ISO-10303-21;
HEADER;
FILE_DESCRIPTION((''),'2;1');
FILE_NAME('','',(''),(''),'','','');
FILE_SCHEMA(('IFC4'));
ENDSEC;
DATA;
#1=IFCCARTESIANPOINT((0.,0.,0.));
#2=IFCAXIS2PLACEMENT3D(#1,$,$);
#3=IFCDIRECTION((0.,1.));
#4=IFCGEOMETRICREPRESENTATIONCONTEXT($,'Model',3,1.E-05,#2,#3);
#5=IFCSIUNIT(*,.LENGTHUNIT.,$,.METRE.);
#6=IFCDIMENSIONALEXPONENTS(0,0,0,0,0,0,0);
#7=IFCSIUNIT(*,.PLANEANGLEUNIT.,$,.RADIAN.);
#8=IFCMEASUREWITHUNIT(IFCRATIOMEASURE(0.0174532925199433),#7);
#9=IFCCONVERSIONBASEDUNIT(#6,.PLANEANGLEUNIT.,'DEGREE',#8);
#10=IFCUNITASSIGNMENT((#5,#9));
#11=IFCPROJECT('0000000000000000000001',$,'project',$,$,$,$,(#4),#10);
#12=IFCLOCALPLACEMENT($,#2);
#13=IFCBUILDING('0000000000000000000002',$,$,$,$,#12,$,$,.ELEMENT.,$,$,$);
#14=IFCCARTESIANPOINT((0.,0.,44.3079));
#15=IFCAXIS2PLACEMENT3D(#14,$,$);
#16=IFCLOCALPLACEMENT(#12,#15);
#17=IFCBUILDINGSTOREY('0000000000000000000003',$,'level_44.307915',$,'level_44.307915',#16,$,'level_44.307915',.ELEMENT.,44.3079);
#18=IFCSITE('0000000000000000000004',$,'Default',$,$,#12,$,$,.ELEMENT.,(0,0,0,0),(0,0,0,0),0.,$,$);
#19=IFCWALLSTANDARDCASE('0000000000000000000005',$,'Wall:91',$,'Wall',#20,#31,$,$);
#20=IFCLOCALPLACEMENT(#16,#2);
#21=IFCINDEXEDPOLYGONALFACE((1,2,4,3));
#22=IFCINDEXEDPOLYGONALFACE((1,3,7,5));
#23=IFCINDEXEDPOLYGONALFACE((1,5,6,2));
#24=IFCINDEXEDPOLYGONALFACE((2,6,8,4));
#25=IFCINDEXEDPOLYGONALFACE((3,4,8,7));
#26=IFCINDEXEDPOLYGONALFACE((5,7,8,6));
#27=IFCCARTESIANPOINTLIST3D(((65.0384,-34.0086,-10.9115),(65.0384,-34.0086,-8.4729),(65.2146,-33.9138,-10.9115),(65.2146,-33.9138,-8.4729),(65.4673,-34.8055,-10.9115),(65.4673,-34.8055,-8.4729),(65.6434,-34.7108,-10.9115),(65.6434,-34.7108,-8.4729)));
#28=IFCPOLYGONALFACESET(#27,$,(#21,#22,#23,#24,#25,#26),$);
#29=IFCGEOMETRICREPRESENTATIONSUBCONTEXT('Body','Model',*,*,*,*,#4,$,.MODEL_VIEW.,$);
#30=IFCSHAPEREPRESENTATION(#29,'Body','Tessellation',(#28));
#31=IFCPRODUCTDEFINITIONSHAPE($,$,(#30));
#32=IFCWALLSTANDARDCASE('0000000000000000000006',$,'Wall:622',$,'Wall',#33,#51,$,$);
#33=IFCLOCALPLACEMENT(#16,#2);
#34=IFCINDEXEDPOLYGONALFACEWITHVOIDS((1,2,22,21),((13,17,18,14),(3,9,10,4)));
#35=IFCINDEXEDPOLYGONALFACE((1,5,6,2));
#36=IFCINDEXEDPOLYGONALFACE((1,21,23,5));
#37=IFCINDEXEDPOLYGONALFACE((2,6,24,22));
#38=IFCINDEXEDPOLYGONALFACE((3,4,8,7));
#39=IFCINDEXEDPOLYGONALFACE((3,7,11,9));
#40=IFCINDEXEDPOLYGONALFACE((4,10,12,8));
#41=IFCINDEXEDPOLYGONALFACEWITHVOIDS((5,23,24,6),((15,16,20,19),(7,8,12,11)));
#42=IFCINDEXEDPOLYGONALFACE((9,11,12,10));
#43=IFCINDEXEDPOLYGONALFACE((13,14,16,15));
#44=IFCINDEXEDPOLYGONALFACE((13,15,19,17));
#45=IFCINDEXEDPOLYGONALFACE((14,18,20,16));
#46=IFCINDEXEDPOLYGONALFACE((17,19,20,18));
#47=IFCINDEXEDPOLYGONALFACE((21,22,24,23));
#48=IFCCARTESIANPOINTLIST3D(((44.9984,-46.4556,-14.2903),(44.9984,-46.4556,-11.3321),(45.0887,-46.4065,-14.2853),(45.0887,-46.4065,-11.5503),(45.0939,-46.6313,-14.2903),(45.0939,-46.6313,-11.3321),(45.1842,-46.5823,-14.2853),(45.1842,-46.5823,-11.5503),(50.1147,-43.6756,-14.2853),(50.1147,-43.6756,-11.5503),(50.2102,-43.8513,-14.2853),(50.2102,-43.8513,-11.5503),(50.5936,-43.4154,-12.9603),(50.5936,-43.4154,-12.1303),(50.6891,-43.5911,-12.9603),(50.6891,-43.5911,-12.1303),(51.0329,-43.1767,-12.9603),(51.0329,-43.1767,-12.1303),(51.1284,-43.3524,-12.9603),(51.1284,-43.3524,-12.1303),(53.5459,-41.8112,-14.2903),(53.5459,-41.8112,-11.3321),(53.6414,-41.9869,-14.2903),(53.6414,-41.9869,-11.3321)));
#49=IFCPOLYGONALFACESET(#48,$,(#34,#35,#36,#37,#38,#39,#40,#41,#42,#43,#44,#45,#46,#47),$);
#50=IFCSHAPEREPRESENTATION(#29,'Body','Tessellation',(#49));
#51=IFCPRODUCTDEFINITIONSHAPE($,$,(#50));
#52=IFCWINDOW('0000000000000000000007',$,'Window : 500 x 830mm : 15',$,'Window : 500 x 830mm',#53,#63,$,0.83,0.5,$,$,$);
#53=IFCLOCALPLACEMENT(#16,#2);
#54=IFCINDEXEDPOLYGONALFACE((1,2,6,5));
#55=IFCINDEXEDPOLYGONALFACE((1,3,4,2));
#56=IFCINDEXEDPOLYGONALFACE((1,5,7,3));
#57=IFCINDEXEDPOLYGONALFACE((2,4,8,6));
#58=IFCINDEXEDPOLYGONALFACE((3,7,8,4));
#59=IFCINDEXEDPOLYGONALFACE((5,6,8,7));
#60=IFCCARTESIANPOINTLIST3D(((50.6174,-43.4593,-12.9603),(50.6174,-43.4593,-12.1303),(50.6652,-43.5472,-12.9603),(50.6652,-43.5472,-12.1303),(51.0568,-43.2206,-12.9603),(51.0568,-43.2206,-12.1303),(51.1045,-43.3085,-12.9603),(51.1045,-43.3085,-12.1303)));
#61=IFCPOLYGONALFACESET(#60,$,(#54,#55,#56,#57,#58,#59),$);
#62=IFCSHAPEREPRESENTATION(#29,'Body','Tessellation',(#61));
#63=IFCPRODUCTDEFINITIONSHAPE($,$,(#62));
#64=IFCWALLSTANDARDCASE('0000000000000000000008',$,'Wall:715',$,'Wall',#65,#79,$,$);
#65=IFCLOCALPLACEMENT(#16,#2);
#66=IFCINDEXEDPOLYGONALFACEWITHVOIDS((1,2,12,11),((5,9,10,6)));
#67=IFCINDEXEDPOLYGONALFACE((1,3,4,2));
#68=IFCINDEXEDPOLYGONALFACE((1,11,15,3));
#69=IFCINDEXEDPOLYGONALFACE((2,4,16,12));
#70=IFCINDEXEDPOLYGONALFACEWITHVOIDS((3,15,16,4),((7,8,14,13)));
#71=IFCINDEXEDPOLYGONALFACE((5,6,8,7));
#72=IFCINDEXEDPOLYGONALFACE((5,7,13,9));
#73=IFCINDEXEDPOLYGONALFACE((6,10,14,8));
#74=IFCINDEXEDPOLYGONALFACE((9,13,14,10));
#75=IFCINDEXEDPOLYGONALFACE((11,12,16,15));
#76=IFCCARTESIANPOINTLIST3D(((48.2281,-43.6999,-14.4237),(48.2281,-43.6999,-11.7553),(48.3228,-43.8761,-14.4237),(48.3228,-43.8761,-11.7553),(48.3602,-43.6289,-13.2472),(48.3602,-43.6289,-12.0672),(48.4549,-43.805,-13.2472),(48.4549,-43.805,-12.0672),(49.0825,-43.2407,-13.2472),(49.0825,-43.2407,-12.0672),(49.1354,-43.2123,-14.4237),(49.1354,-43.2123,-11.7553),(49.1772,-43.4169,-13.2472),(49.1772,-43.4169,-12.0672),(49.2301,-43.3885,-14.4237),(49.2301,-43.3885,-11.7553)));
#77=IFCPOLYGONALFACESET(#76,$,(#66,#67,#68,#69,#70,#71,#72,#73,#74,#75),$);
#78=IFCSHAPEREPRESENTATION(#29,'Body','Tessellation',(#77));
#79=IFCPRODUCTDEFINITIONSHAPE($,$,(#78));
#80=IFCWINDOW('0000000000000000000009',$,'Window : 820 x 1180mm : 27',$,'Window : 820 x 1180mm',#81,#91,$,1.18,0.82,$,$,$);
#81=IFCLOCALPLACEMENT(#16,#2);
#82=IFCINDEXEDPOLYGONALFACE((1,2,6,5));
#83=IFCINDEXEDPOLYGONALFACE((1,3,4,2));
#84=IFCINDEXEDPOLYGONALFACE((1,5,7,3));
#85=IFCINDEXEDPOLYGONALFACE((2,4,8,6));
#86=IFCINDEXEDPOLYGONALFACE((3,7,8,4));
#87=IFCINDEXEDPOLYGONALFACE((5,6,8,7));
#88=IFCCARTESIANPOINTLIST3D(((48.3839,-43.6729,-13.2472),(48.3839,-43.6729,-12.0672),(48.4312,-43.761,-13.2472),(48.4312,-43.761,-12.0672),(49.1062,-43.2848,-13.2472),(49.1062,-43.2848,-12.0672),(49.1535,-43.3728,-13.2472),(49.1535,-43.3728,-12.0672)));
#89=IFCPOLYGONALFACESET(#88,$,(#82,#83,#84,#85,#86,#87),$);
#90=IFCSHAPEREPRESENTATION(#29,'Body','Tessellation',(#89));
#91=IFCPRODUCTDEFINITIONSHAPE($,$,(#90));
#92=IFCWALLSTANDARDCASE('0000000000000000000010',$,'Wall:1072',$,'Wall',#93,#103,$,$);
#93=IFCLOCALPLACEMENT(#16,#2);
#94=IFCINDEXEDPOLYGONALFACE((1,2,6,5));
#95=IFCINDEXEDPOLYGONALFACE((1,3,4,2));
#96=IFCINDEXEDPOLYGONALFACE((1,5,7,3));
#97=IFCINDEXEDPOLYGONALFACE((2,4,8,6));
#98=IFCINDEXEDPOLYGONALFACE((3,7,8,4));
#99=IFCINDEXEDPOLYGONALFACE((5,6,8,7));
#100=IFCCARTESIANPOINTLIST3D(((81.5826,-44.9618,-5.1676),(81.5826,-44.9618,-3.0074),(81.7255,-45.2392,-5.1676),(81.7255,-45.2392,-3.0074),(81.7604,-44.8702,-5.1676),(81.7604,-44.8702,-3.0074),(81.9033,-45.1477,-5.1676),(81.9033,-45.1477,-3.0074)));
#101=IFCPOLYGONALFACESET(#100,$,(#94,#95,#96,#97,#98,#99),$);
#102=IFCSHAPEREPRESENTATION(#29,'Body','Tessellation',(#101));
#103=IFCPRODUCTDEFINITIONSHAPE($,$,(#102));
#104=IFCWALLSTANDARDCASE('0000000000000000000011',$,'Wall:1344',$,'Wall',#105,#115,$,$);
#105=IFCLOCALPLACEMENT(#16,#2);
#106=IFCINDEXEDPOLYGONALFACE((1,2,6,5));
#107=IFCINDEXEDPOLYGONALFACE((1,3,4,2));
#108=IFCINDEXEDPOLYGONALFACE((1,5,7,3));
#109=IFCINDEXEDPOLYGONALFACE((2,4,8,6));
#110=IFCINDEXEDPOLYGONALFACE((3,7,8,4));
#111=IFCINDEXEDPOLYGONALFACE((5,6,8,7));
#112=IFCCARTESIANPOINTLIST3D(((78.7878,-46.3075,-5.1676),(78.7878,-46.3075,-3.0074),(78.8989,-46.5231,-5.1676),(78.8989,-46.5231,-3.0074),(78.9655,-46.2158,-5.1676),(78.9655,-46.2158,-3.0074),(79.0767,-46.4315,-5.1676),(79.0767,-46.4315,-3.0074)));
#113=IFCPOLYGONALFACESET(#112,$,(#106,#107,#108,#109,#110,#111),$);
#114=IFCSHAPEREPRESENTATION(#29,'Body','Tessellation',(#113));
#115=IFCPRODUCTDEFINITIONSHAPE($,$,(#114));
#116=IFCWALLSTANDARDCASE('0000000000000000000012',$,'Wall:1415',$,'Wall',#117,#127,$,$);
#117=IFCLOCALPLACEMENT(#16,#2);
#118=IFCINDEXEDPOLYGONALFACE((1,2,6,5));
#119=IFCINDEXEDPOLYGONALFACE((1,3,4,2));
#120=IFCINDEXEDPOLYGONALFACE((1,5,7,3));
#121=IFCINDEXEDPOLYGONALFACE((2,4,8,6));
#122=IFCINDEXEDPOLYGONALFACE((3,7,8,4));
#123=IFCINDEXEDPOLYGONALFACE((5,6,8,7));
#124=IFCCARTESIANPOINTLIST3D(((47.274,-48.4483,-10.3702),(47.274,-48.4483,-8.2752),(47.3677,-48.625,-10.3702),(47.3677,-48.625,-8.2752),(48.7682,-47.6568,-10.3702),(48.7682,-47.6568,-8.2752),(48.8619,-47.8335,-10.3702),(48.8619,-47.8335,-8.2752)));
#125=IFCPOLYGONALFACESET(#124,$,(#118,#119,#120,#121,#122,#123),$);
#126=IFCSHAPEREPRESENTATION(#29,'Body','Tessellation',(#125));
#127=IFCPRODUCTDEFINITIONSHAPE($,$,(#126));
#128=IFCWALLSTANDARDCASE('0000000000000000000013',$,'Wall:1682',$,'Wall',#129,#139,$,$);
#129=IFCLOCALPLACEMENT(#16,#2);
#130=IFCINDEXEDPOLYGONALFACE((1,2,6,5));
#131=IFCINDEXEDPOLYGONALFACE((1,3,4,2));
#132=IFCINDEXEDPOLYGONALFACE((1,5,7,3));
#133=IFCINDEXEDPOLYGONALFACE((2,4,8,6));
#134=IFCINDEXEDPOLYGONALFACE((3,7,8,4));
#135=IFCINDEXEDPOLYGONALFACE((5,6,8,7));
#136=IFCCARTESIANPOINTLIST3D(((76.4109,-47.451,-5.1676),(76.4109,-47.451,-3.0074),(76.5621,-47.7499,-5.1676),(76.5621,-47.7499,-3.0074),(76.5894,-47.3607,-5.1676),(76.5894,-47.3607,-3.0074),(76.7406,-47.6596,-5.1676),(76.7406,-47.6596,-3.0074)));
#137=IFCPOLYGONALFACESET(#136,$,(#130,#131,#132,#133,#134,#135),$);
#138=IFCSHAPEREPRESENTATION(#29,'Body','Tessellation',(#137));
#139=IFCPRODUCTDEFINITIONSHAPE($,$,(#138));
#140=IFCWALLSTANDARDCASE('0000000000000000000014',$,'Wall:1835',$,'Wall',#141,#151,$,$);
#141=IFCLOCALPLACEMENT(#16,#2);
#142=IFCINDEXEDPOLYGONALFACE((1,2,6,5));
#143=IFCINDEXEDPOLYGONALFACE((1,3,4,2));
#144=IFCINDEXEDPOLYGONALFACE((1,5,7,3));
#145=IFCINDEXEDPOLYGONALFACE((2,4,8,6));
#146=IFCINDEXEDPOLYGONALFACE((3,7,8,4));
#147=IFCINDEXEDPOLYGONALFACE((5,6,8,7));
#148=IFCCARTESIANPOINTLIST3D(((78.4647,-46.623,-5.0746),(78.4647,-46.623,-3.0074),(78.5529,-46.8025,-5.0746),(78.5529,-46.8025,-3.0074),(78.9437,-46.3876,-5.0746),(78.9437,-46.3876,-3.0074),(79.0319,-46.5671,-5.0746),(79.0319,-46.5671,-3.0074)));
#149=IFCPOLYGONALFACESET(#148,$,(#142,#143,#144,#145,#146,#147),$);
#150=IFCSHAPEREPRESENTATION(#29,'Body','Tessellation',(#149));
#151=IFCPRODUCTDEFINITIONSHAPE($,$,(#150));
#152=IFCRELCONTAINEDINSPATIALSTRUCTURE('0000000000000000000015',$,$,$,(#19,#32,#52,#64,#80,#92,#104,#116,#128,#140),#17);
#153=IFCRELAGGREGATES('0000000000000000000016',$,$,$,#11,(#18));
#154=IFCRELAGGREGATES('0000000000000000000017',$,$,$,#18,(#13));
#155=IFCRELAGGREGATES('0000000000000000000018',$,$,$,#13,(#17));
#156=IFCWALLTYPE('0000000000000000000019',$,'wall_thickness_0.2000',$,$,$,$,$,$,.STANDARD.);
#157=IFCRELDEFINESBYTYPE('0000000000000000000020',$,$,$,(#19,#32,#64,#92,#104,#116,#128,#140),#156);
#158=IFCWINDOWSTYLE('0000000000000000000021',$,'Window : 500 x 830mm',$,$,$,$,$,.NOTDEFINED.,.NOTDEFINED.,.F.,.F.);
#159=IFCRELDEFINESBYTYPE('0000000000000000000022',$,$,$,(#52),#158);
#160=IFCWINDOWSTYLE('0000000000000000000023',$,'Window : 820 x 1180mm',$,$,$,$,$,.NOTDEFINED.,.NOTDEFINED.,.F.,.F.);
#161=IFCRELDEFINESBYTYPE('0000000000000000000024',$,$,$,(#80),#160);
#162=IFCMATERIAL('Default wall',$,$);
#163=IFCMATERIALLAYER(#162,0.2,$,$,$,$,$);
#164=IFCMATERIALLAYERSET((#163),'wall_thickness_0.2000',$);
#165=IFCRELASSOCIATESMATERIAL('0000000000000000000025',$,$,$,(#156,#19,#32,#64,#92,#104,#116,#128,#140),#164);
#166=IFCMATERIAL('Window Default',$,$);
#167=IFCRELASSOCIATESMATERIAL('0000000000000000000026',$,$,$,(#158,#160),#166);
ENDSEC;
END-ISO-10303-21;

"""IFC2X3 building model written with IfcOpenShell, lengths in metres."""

from ifc_helpers import new_model, entity, si_unit, converted_unit, direction, frame, frame_2d, origin, origin_2d_with_axis, place, context, subcontext, project, spatial, polyline, rectangle, outline, extrude, source, transform, mapped, material, layer, layer_set, layer_usage, type_object, type_shapes, element, fill, save


model = new_model("IFC2X3")

# Units and contexts
model_context = context("Model", 3, precision=1e-05, world=origin(), true_north=direction((0.0, 1.0)))
body_context = subcontext(model_context, "Body", "Model", "MODEL_VIEW")
ifc_project = project(units=[si_unit("LENGTHUNIT", "METRE"), converted_unit("PLANEANGLEUNIT", "DEGREE", entity("IfcRatioMeasure", 0.0174532925199433), si_unit("PLANEANGLEUNIT", "RADIAN"), dimensions=[0, 0, 0, 0, 0, 0, 0])], contexts=[model_context])

# Site, building, storey
placement_1 = place(None, origin())
site = spatial("IfcSite", under=ifc_project, at=placement_1, Name="Default", CompositionType="ELEMENT", RefLatitude=(0, 0, 0, 0), RefLongitude=(0, 0, 0, 0), RefElevation=0.0)
building = spatial("IfcBuilding", under=site, at=placement_1, CompositionType="ELEMENT")
storey_placement = place(placement_1, frame((0.0, 0.0, 44.3079)))
storey = spatial("IfcBuildingStorey", under=building, at=storey_placement, Name="level_44.307915", ObjectType="level_44.307915", LongName="level_44.307915", CompositionType="ELEMENT", Elevation=44.3079)

# Wall
ifc_material_1 = material(Name="Default wall")
ifc_layer = layer(ifc_material_1, 0.2)
ifc_layer_set = layer_set([ifc_layer], Name="wall_thickness_0.2000")
ifc_layer_usage = layer_usage(ifc_layer_set, "AXIS2", "POSITIVE", -0.1)
wall_type = type_object("IfcWallType", Name="wall_thickness_0.2000", PredefinedType="STANDARD", material=ifc_layer_set)
placement_2 = place(placement_1, frame((0.0, 0.0, 33.3964)))
wall_1_placement = place(placement_2, frame((65.5553, -34.7582, 0.0), z_axis=(0.0, 0.0, 1.0), x_axis=(-0.473866, 0.880597, 0.0)))
element("IfcWallStandardCase", 1, at=wall_1_placement, inside=storey, type_object=wall_type, material=ifc_layer_usage, Name="Wall:91", ObjectType="Wall", context=body_context, shape_type="SweptSolid", body=[
    extrude(outline(polyline([(0.905, -0.1), (0.905, 0.1), (0.0, 0.1), (0.0, -0.1), (0.905, -0.1)])), origin(), (0.0, 0.0, 1.0), 2.4386),
])

# Wall, openings, window
placement_3 = place(placement_1, frame((0.0, 0.0, 30.0176)))
wall_2_placement = place(placement_3, frame((45.0461, -46.5435, 0.0), z_axis=(0.0, 0.0, 1.0), x_axis=(0.878667, 0.477436, 0.0)))
wall_2 = element("IfcWallStandardCase", 2, at=wall_2_placement, inside=storey, type_object=wall_type, material=ifc_layer_usage, Name="Wall:622", ObjectType="Wall", context=body_context, shape_type="SweptSolid", body=[
    extrude(outline(polyline([(9.7278, -0.1), (9.7278, 0.1), (0.0, 0.1), (0.0, -0.1), (9.7278, -0.1)])), origin(), (0.0, 0.0, 1.0), 2.9582),
])
opening_1_placement = place(wall_2_placement, frame((0.1028, -0.1, 0.005)))
element("IfcOpeningElement", 3, at=opening_1_placement, cuts=wall_2, ObjectType="Opening", context=body_context, shape_type="SweptSolid", body=[
    extrude(rectangle(XDim=5.72, YDim=2.735, at=frame_2d((1.3675, 2.86), x_axis=(0.0, 1.0))), frame((0.0, 0.0, 0.0), z_axis=(0.0, 1.0, 0.0), x_axis=(0.0, 0.0, 1.0)), (0.0, 0.0, 1.0), 0.2),
])
opening_2_placement = place(wall_2_placement, frame((6.3678, -0.1, 1.33)))
opening_2 = element("IfcOpeningElement", 4, at=opening_2_placement, cuts=wall_2, ObjectType="Opening", context=body_context, shape_type="SweptSolid", body=[
    extrude(rectangle(XDim=0.5, YDim=0.83, at=frame_2d((0.415, 0.25), x_axis=(0.0, 1.0))), frame((0.0, 0.0, 0.0), z_axis=(0.0, 1.0, 0.0), x_axis=(0.0, 0.0, 1.0)), (0.0, 0.0, 1.0), 0.2),
])
ifc_material_2 = material(Name="Window Default")
window_style_1 = type_object("IfcWindowStyle", Name="Window : 500 x 830mm", ConstructionType="NOTDEFINED", OperationType="NOTDEFINED", ParameterTakesPrecedence=False, Sizeable=False, material=ifc_material_2)
shared_shape_1 = source(origin(), body_context, "Body", "SweptSolid", [
    extrude(rectangle(XDim=0.1, YDim=0.5, at=origin_2d_with_axis()), frame((0.25, 0.1, 0.0), z_axis=(0.0, 0.0, 1.0), x_axis=(0.0, 1.0, 0.0)), (0.0, 0.0, 1.0), 0.83),
])
type_shapes(window_style_1, [shared_shape_1])
window_1_placement = place(opening_2_placement, origin())
window_1 = element("IfcWindow", 5, at=window_1_placement, inside=storey, type_object=window_style_1, Name="Window : 500 x 830mm : 15", ObjectType="Window : 500 x 830mm", OverallHeight=0.83, OverallWidth=0.5, context=body_context, shape_type="MappedRepresentation", body=[
    mapped(shared_shape_1, transform((0.0, 0.0, 0.0), scale=1.0)),
])
fill(opening_2, window_1)

# Wall, opening, window
placement_4 = place(placement_1, frame((0.0, 0.0, 29.8842)))
wall_3_placement = place(placement_4, frame((48.2754, -43.788, 0.0), z_axis=(0.0, 0.0, 1.0), x_axis=(0.880861, 0.473374, 0.0)))
wall_3 = element("IfcWallStandardCase", 6, at=wall_3_placement, inside=storey, type_object=wall_type, material=ifc_layer_usage, Name="Wall:715", ObjectType="Wall", context=body_context, shape_type="SweptSolid", body=[
    extrude(outline(polyline([(1.03, -0.1), (1.03, 0.1), (0.0, 0.1), (0.0, -0.1), (1.03, -0.1)])), origin(), (0.0, 0.0, 1.0), 2.6684),
])
opening_3_placement = place(wall_3_placement, frame((0.15, -0.1, 1.1765)))
opening_3 = element("IfcOpeningElement", 7, at=opening_3_placement, cuts=wall_3, ObjectType="Opening", context=body_context, shape_type="SweptSolid", body=[
    extrude(rectangle(XDim=0.82, YDim=1.18, at=frame_2d((0.59, 0.41), x_axis=(0.0, 1.0))), frame((0.0, 0.0, 0.0), z_axis=(0.0, 1.0, 0.0), x_axis=(0.0, 0.0, 1.0)), (0.0, 0.0, 1.0), 0.2),
])
window_style_2 = type_object("IfcWindowStyle", Name="Window : 820 x 1180mm", ConstructionType="NOTDEFINED", OperationType="NOTDEFINED", ParameterTakesPrecedence=False, Sizeable=False, material=ifc_material_2)
shared_shape_2 = source(origin(), body_context, "Body", "SweptSolid", [
    extrude(rectangle(XDim=0.1, YDim=0.82, at=origin_2d_with_axis()), frame((0.41, 0.1, 0.0), z_axis=(0.0, 0.0, 1.0), x_axis=(0.0, 1.0, 0.0)), (0.0, 0.0, 1.0), 1.18),
])
type_shapes(window_style_2, [shared_shape_2])
window_2_placement = place(opening_3_placement, origin())
window_2 = element("IfcWindow", 8, at=window_2_placement, inside=storey, type_object=window_style_2, Name="Window : 820 x 1180mm : 27", ObjectType="Window : 820 x 1180mm", OverallHeight=1.18, OverallWidth=0.82, context=body_context, shape_type="MappedRepresentation", body=[
    mapped(shared_shape_2, transform((0.0, 0.0, 0.0), scale=1.0)),
])
fill(opening_3, window_2)

# Walls
placement_5 = place(placement_1, frame((0.0, 0.0, 39.1403)))
wall_4_placement = place(placement_5, frame((81.6715, -44.916, 0.0), z_axis=(0.0, 0.0, 1.0), x_axis=(0.457798, -0.889056, 0.0)))
element("IfcWallStandardCase", 9, at=wall_4_placement, inside=storey, type_object=wall_type, material=ifc_layer_usage, Name="Wall:1072", ObjectType="Wall", context=body_context, shape_type="SweptSolid", body=[
    extrude(outline(polyline([(0.3121, -0.1), (0.3121, 0.1), (0.0, 0.1), (0.0, -0.1), (0.3121, -0.1)])), origin(), (0.0, 0.0, 1.0), 2.1602),
])
placement_6 = place(placement_1, frame((0.0, 0.0, 39.1403)))
wall_5_placement = place(placement_6, frame((78.9878, -46.4773, 0.0), z_axis=(0.0, 0.0, 1.0), x_axis=(-0.458111, 0.888895, 0.0)))
element("IfcWallStandardCase", 10, at=wall_5_placement, inside=storey, type_object=wall_type, material=ifc_layer_usage, Name="Wall:1344", ObjectType="Wall", context=body_context, shape_type="SweptSolid", body=[
    extrude(outline(polyline([(0.2426, -0.1), (0.2426, 0.1), (0.0, 0.1), (0.0, -0.1), (0.2426, -0.1)])), origin(), (0.0, 0.0, 1.0), 2.1602),
])
placement_7 = place(placement_1, frame((0.0, 0.0, 33.9377)))
wall_6_placement = place(placement_7, frame((48.815, -47.7452, 0.0), z_axis=(0.0, 0.0, 1.0), x_axis=(-0.883676, -0.468098, 0.0)))
element("IfcWallStandardCase", 11, at=wall_6_placement, inside=storey, type_object=wall_type, material=ifc_layer_usage, Name="Wall:1415", ObjectType="Wall", context=body_context, shape_type="SweptSolid", body=[
    extrude(outline(polyline([(1.6909, -0.1), (1.6909, 0.1), (0.0, 0.1), (0.0, -0.1), (1.6909, -0.1)])), origin(), (0.0, 0.0, 1.0), 2.095),
])
placement_8 = place(placement_1, frame((0.0, 0.0, 39.1403)))
wall_7_placement = place(placement_8, frame((76.5002, -47.4059, 0.0), z_axis=(0.0, 0.0, 1.0), x_axis=(0.451345, -0.892349, 0.0)))
element("IfcWallStandardCase", 12, at=wall_7_placement, inside=storey, type_object=wall_type, material=ifc_layer_usage, Name="Wall:1682", ObjectType="Wall", context=body_context, shape_type="SweptSolid", body=[
    extrude(outline(polyline([(0.335, -0.1), (0.335, 0.1), (0.0, 0.1), (0.0, -0.1), (0.335, -0.1)])), origin(), (0.0, 0.0, 1.0), 2.1602),
])
placement_9 = place(placement_1, frame((0.0, 0.0, 39.2333)))
wall_8_placement = place(placement_9, frame((78.5088, -46.7128, 0.0), z_axis=(0.0, 0.0, 1.0), x_axis=(0.897437, 0.441143, 0.0)))
element("IfcWallStandardCase", 13, at=wall_8_placement, inside=storey, type_object=wall_type, material=ifc_layer_usage, Name="Wall:1835", ObjectType="Wall", context=body_context, shape_type="SweptSolid", body=[
    extrude(outline(polyline([(0.5338, -0.1), (0.5338, 0.1), (0.0, 0.1), (0.0, -0.1), (0.5338, -0.1)])), origin(), (0.0, 0.0, 1.0), 2.0672),
])

save(model, "model.ifc")
